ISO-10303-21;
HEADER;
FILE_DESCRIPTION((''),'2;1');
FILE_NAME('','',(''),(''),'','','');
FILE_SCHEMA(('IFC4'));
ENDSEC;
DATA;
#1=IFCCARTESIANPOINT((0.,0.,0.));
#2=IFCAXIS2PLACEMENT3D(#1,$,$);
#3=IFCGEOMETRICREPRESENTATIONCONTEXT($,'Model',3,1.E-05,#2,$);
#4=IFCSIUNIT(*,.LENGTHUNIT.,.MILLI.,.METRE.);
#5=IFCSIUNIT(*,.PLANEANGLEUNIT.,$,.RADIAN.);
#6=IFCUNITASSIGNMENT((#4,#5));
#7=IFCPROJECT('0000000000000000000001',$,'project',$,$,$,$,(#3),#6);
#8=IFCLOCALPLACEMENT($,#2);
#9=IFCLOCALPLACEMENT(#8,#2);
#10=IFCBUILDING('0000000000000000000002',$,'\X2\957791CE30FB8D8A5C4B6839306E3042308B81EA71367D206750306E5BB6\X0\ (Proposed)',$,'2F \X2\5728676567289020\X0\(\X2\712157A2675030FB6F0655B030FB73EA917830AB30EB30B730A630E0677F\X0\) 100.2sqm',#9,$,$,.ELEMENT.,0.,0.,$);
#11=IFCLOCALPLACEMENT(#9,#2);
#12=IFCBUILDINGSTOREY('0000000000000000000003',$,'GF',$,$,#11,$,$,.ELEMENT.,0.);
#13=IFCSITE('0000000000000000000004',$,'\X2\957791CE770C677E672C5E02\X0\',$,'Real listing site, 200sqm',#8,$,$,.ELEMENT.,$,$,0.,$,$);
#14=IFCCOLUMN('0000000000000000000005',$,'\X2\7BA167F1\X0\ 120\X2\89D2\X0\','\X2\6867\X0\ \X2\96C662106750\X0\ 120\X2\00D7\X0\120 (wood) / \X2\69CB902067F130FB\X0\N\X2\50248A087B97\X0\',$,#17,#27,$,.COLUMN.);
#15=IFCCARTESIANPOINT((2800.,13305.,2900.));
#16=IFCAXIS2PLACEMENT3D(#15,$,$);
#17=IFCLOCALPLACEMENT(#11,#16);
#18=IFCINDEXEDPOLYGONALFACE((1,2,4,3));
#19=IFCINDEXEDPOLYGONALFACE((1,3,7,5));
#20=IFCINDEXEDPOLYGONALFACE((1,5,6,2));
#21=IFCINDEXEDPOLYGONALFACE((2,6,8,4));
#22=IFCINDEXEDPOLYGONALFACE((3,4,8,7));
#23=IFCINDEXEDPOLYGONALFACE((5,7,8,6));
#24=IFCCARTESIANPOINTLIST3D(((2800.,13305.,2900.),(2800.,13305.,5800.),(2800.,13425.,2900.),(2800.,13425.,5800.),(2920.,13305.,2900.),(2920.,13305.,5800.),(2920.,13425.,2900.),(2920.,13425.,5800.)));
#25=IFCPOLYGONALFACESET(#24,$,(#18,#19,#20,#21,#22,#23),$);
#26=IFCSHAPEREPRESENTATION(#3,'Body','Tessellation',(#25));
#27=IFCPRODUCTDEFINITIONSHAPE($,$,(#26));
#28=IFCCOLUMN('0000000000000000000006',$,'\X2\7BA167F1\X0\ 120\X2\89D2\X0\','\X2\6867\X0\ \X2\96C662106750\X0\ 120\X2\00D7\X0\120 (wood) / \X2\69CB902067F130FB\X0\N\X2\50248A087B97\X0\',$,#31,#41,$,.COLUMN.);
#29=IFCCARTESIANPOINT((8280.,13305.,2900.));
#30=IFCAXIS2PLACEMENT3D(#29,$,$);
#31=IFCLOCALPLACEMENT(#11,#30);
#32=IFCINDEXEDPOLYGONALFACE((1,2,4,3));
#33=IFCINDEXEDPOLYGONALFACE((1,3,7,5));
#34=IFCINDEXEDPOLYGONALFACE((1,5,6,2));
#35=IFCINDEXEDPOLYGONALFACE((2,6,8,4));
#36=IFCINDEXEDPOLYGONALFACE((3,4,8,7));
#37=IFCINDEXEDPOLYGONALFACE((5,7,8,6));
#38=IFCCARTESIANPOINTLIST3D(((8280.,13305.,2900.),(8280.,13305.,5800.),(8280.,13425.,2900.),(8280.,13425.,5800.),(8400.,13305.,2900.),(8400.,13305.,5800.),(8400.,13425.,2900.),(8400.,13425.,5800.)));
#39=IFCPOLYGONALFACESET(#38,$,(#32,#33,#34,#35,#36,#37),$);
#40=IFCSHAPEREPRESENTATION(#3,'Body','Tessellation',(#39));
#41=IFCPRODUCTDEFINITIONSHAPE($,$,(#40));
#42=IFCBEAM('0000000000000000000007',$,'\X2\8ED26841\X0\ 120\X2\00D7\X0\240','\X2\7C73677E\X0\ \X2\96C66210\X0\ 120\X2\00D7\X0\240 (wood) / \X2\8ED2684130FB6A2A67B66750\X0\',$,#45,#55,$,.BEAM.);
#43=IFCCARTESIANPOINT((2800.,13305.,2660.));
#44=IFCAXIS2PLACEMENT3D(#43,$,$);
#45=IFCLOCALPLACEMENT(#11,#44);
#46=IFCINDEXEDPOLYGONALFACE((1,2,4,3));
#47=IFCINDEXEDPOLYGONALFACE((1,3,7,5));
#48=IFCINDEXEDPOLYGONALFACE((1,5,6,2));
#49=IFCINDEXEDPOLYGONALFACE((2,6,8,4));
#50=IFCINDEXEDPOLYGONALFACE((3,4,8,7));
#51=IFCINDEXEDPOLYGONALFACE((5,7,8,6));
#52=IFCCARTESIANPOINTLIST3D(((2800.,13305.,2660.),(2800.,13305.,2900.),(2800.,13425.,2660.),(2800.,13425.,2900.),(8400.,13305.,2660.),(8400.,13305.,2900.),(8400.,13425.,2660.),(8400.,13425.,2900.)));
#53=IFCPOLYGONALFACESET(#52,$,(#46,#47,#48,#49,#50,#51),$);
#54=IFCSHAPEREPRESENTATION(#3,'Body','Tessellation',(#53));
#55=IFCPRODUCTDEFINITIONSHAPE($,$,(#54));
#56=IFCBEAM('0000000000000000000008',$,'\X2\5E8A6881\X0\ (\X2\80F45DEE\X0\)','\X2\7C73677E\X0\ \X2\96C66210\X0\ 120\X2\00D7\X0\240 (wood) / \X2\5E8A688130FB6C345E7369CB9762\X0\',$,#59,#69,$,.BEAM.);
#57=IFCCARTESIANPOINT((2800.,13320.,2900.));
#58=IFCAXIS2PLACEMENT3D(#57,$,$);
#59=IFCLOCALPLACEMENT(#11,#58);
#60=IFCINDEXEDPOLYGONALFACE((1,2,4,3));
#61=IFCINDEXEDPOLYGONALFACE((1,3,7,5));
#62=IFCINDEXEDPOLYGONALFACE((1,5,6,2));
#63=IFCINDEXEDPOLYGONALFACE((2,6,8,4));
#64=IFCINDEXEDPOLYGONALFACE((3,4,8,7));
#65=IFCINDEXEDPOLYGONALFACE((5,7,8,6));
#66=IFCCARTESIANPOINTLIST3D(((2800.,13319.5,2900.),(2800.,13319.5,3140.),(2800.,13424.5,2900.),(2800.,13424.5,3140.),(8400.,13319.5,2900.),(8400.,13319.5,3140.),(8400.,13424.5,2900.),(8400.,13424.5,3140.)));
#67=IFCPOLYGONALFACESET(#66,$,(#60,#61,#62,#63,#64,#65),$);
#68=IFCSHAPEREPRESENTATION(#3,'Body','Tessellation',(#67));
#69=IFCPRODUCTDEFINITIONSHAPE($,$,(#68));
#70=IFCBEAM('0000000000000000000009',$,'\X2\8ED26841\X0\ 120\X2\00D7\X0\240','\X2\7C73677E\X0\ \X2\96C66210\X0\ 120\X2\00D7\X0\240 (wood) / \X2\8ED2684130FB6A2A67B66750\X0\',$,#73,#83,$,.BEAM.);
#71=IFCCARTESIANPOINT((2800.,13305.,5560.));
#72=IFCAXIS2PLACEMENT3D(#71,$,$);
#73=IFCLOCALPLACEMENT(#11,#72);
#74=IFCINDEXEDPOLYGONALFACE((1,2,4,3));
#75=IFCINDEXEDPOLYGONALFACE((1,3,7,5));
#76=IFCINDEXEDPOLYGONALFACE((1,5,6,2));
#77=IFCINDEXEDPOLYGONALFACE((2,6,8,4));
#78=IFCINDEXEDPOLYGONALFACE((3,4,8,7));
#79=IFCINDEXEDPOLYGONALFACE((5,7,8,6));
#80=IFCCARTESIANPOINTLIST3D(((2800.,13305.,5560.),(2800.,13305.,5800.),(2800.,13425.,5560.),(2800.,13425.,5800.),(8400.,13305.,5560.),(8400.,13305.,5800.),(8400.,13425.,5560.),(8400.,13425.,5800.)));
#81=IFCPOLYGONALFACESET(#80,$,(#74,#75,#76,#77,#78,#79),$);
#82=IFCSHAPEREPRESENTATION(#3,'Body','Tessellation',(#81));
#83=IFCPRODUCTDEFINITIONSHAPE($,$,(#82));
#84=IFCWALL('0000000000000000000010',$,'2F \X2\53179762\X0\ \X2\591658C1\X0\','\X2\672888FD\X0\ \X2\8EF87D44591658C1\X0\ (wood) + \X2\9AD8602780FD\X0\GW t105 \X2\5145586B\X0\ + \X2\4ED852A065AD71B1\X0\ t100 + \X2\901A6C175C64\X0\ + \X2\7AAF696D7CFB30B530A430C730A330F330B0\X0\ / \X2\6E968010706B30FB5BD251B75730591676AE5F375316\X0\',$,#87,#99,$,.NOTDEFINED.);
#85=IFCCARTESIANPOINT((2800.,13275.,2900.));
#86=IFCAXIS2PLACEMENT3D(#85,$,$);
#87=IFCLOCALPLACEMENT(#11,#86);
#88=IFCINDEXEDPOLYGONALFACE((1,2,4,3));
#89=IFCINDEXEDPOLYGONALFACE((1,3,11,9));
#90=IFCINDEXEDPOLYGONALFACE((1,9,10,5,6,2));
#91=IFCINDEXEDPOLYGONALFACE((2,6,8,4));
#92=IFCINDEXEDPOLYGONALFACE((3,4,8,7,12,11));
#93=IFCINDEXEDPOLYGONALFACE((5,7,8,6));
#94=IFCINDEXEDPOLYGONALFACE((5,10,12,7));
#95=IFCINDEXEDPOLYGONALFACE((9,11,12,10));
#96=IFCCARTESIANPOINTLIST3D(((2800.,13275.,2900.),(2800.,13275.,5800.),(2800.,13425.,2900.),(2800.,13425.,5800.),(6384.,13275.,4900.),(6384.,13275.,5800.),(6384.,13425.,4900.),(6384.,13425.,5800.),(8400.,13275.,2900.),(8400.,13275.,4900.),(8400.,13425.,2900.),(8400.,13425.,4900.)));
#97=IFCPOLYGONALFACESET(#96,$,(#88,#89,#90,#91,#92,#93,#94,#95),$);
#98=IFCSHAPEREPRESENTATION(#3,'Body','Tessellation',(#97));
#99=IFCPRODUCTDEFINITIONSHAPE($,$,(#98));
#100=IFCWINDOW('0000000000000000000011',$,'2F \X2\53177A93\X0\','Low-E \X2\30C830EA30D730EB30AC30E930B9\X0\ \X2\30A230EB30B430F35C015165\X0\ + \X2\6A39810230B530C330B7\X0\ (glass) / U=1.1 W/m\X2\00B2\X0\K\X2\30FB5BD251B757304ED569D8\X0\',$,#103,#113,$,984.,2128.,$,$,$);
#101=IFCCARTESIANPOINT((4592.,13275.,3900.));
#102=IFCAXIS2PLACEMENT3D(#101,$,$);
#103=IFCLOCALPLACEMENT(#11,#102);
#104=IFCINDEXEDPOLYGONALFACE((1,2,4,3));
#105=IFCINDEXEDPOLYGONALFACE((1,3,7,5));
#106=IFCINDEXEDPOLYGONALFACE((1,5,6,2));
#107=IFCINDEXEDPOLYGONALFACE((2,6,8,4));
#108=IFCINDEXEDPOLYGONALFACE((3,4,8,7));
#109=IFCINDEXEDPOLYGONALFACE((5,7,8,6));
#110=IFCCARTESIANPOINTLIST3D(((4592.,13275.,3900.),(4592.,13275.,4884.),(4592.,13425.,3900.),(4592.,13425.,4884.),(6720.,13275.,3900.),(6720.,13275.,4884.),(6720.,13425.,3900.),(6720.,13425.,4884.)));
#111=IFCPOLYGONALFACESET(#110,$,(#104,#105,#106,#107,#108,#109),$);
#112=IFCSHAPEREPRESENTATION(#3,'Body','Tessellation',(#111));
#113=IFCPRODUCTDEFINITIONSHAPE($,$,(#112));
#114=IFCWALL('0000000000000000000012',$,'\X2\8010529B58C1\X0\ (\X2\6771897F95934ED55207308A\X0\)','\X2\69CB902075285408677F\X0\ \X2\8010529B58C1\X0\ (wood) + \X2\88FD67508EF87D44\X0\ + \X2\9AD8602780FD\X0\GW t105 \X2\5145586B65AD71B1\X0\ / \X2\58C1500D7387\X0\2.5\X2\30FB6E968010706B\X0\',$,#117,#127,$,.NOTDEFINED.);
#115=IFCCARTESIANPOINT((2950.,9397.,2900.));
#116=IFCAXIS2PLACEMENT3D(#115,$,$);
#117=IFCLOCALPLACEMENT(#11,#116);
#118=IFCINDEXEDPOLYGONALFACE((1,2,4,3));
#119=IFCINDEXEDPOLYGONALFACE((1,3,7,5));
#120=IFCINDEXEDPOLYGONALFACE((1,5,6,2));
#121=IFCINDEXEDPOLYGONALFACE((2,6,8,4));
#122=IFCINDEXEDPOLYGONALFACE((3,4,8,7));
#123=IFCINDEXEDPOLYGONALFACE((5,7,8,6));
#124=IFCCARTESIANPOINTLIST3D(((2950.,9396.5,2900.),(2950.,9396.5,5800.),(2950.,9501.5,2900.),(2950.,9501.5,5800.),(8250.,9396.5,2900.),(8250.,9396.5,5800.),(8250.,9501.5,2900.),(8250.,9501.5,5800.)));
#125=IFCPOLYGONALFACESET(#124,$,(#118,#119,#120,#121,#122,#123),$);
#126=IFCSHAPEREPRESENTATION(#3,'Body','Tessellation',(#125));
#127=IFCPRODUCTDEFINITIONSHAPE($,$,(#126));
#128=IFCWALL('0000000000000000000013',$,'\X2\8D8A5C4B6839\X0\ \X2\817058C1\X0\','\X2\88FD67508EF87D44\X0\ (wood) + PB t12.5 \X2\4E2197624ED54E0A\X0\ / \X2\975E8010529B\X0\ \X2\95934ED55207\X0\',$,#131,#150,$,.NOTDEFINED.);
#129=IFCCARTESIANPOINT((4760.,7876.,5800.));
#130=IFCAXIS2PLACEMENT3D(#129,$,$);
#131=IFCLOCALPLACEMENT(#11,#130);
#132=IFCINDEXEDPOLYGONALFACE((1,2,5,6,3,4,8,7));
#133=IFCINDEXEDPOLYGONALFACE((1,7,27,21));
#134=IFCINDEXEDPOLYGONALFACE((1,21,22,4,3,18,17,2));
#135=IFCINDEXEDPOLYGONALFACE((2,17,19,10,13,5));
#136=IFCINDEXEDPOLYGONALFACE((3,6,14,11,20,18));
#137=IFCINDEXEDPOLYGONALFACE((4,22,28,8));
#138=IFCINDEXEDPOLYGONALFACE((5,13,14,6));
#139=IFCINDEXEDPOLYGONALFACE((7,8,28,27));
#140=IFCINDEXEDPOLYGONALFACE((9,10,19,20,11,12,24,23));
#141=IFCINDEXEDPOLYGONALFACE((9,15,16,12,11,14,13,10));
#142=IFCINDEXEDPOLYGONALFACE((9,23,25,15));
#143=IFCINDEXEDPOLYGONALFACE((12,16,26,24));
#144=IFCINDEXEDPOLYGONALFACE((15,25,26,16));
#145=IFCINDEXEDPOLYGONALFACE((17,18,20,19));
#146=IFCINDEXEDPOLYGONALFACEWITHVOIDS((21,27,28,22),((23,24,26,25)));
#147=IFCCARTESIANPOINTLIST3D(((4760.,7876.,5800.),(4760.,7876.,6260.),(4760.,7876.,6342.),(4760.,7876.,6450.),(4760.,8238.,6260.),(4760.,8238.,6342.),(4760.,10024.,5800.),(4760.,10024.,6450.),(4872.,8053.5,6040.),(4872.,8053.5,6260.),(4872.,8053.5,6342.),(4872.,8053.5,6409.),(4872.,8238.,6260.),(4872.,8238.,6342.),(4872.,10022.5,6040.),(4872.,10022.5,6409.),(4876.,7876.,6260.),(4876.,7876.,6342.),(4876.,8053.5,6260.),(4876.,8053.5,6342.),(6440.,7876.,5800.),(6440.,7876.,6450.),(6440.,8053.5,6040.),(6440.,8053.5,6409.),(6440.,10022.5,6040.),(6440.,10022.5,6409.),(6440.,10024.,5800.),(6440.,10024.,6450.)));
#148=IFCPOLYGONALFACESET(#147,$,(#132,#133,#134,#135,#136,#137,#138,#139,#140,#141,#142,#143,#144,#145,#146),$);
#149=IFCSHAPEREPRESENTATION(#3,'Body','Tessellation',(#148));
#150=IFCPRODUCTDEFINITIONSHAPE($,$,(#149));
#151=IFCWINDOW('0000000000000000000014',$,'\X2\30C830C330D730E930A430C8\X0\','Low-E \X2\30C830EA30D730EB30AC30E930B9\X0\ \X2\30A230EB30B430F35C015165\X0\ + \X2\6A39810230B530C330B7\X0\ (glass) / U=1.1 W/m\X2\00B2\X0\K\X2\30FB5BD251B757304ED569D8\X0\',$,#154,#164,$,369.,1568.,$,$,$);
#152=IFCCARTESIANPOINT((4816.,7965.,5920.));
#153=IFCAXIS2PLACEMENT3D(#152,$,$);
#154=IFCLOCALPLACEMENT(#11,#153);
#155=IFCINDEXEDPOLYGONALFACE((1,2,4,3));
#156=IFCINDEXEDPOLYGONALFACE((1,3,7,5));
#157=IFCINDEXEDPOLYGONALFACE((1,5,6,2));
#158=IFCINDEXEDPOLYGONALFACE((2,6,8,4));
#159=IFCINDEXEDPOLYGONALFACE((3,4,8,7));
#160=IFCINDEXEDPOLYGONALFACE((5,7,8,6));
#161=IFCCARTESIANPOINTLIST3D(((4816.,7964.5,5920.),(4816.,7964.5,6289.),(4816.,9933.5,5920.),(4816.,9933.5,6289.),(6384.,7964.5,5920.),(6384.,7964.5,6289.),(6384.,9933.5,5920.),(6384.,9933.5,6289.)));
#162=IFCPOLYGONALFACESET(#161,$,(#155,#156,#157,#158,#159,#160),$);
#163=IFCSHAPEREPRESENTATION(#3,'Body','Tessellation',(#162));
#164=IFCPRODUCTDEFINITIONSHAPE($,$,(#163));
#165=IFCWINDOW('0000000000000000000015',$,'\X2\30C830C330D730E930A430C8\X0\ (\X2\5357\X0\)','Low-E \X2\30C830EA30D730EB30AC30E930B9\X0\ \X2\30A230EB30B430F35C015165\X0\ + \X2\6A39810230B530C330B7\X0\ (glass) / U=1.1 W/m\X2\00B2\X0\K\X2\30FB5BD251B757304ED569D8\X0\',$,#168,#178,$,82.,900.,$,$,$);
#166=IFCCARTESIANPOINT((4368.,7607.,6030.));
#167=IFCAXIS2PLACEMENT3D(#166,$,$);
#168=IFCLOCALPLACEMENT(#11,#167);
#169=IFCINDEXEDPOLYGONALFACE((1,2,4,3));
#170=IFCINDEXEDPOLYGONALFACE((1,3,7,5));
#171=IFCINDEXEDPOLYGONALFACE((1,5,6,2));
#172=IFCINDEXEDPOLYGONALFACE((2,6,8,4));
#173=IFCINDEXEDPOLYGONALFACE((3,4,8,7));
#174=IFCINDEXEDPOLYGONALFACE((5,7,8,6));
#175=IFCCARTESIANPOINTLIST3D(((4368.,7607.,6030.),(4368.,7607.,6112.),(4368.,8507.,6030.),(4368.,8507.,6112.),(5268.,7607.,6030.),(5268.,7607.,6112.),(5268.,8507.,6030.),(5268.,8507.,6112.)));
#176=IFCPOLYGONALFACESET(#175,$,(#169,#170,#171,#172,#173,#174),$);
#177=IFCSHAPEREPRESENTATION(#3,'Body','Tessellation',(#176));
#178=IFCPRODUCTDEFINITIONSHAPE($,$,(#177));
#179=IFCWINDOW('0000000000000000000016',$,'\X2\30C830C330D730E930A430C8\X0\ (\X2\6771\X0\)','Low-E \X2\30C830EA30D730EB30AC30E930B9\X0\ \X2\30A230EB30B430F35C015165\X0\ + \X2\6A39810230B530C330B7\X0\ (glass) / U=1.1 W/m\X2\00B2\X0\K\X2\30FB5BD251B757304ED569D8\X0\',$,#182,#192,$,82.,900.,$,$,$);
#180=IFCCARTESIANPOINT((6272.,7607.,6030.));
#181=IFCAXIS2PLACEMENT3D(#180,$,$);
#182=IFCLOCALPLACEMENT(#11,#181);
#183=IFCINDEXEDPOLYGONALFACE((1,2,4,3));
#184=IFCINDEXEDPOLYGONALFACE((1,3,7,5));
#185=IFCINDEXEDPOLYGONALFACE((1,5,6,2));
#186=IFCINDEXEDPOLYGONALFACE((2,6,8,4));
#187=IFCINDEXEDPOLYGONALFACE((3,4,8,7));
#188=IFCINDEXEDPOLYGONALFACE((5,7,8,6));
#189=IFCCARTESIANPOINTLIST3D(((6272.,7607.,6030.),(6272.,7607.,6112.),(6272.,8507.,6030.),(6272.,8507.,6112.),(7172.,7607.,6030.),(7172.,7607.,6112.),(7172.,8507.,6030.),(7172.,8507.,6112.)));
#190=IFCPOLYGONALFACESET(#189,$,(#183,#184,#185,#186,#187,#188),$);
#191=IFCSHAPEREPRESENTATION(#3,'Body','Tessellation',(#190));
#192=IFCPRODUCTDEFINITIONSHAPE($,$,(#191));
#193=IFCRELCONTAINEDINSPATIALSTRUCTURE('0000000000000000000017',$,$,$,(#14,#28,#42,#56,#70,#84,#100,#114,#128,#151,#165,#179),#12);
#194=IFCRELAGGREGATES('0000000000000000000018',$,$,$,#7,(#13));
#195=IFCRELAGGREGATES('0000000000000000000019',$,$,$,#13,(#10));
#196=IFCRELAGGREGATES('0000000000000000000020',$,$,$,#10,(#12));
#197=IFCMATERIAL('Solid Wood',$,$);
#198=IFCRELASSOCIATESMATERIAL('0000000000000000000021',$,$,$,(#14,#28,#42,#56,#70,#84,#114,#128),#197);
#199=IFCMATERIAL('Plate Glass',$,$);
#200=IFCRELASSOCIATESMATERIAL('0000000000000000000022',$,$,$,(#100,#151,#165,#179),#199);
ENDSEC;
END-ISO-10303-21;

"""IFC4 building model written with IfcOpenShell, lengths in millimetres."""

from ifc_helpers import new_model, si_unit, frame, frame_2d, origin, place, context, project, spatial, rectangle, extrude, material, element, fill, save


model = new_model("IFC4")

# Units and contexts
model_context = context("Model", 3, precision=1e-05, world=origin())
ifc_project = project(units=[si_unit("LENGTHUNIT", "METRE", prefix="MILLI"), si_unit("PLANEANGLEUNIT", "RADIAN")], contexts=[model_context])

# Site, building, storey
site_placement = place(None, origin())
site = spatial("IfcSite", under=ifc_project, at=site_placement, Name="長野県松本市", ObjectType="Real listing site, 200sqm", CompositionType="ELEMENT", RefElevation=0.0)
building_placement = place(site_placement, origin())
building = spatial("IfcBuilding", under=site, at=building_placement, Name="長野・越屋根のある自然素材の家 (Proposed)", ObjectType="2F 在来木造(無垢材・漆喰・珪酸カルシウム板) 100.2sqm", CompositionType="ELEMENT", ElevationOfRefHeight=0.0, ElevationOfTerrain=0.0)
storey_placement = place(building_placement, origin())
storey = spatial("IfcBuildingStorey", under=building, at=storey_placement, Name="GF", CompositionType="ELEMENT", Elevation=0.0)

# Columns
ifc_material_1 = material(Name="Solid Wood")
column_1_placement = place(storey_placement, frame((2800.0, 13305.0, 2900.0)))
element("IfcColumn", 1, at=column_1_placement, inside=storey, material=ifc_material_1, Name="管柱 120角", Description="桧 集成材 120×120 (wood) / 構造柱・N値計算", PredefinedType="COLUMN", context=model_context, shape_type="SweptSolid", body=[
    extrude(rectangle(XDim=120.0, YDim=120.0, at=frame_2d((60.0, 60.0))), frame((2800.0, 13305.0, 2900.0)), (0.0, 0.0, 1.0), 2900.0),
])
column_2_placement = place(storey_placement, frame((8280.0, 13305.0, 2900.0)))
element("IfcColumn", 2, at=column_2_placement, inside=storey, material=ifc_material_1, Name="管柱 120角", Description="桧 集成材 120×120 (wood) / 構造柱・N値計算", PredefinedType="COLUMN", context=model_context, shape_type="SweptSolid", body=[
    extrude(rectangle(XDim=120.0, YDim=120.0, at=frame_2d((60.0, 60.0))), frame((8280.0, 13305.0, 2900.0)), (0.0, 0.0, 1.0), 2900.0),
])

# Beams
beam_1_placement = place(storey_placement, frame((2800.0, 13305.0, 2660.0)))
element("IfcBeam", 3, at=beam_1_placement, inside=storey, material=ifc_material_1, Name="軒桁 120×240", Description="米松 集成 120×240 (wood) / 軒桁・横架材", PredefinedType="BEAM", context=model_context, shape_type="SweptSolid", body=[
    extrude(rectangle(XDim=5600.0, YDim=120.0, at=frame_2d((2800.0, 60.0))), frame((2800.0, 13305.0, 2660.0)), (0.0, 0.0, 1.0), 240.0),
])
beam_2_placement = place(storey_placement, frame((2800.0, 13320.0, 2900.0)))
element("IfcBeam", 4, at=beam_2_placement, inside=storey, material=ifc_material_1, Name="床梁 (胴差)", Description="米松 集成 120×240 (wood) / 床梁・水平構面", PredefinedType="BEAM", context=model_context, shape_type="SweptSolid", body=[
    extrude(rectangle(XDim=5600.0, YDim=105.0, at=frame_2d((2800.0, 52.0))), frame((2800.0, 13320.0, 2900.0)), (0.0, 0.0, 1.0), 240.0),
])
beam_3_placement = place(storey_placement, frame((2800.0, 13305.0, 5560.0)))
element("IfcBeam", 5, at=beam_3_placement, inside=storey, material=ifc_material_1, Name="軒桁 120×240", Description="米松 集成 120×240 (wood) / 軒桁・横架材", PredefinedType="BEAM", context=model_context, shape_type="SweptSolid", body=[
    extrude(rectangle(XDim=5600.0, YDim=120.0, at=frame_2d((2800.0, 60.0))), frame((2800.0, 13305.0, 5560.0)), (0.0, 0.0, 1.0), 240.0),
])

# Wall, opening, window
wall_1_placement = place(storey_placement, frame((2800.0, 13275.0, 2900.0)))
wall_1 = element("IfcWall", 6, at=wall_1_placement, inside=storey, material=ifc_material_1, Name="2F 北面 外壁", Description="木製 軸組外壁 (wood) + 高性能GW t105 充填 + 付加断熱 t100 + 通気層 + 窯業系サイディング / 準耐火・寒冷地外皮強化", PredefinedType="NOTDEFINED", context=model_context, shape_type="SweptSolid", body=[
    extrude(rectangle(XDim=5600.0, YDim=150.0, at=frame_2d((2800.0, 75.0))), frame((2800.0, 13275.0, 2900.0)), (0.0, 0.0, 1.0), 2900.0),
])
opening_1_placement = place(storey_placement, frame((4592.0, 13275.0, 3900.0)))
opening_1 = element("IfcOpeningElement", 7, at=opening_1_placement, cuts=wall_1, PredefinedType="NOTDEFINED", context=model_context, shape_type="SweptSolid", body=[
    extrude(rectangle(XDim=2128.0, YDim=150.0, at=frame_2d((1064.0, 75.0))), frame((4592.0, 13275.0, 3900.0)), (0.0, 0.0, 1.0), 984.0),
])
ifc_material_2 = material(Name="Plate Glass")
window_1_placement = place(storey_placement, frame((4592.0, 13275.0, 3900.0)))
window_1 = element("IfcWindow", 8, at=window_1_placement, inside=storey, material=ifc_material_2, Name="2F 北窓", Description="Low-E トリプルガラス アルゴン封入 + 樹脂サッシ (glass) / U=1.1 W/m²K・寒冷地仕様", OverallHeight=984.0, OverallWidth=2128.0, context=model_context, shape_type="SweptSolid", body=[
    extrude(rectangle(XDim=2128.0, YDim=150.0, at=frame_2d((1064.0, 75.0))), frame((4592.0, 13275.0, 3900.0)), (0.0, 0.0, 1.0), 984.0),
])
fill(opening_1, window_1)

# Wall
wall_2_placement = place(storey_placement, frame((2950.0, 9397.0, 2900.0)))
element("IfcWall", 9, at=wall_2_placement, inside=storey, material=ifc_material_1, Name="耐力壁 (東西間仕切り)", Description="構造用合板 耐力壁 (wood) + 製材軸組 + 高性能GW t105 充填断熱 / 壁倍率2.5・準耐火", PredefinedType="NOTDEFINED", context=model_context, shape_type="SweptSolid", body=[
    extrude(rectangle(XDim=5300.0, YDim=105.0, at=frame_2d((2650.0, 52.0))), frame((2950.0, 9397.0, 2900.0)), (0.0, 0.0, 1.0), 2900.0),
])

# Wall, openings, windows
wall_3_placement = place(storey_placement, frame((4760.0, 7876.0, 5800.0)))
wall_3 = element("IfcWall", 10, at=wall_3_placement, inside=storey, material=ifc_material_1, Name="越屋根 腰壁", Description="製材軸組 (wood) + PB t12.5 両面仕上 / 非耐力 間仕切", PredefinedType="NOTDEFINED", context=model_context, shape_type="SweptSolid", body=[
    extrude(rectangle(XDim=1680.0, YDim=2148.0, at=frame_2d((840.0, 1074.0))), frame((4760.0, 7876.0, 5800.0)), (0.0, 0.0, 1.0), 650.0),
])
opening_2_placement = place(storey_placement, frame((4816.0, 7965.0, 5920.0)))
opening_2 = element("IfcOpeningElement", 11, at=opening_2_placement, cuts=wall_3, PredefinedType="NOTDEFINED", context=model_context, shape_type="SweptSolid", body=[
    extrude(rectangle(XDim=1568.0, YDim=1969.0, at=frame_2d((784.0, 984.0))), frame((4816.0, 7965.0, 5920.0)), (0.0, 0.0, 1.0), 369.0),
])
opening_3_placement = place(storey_placement, frame((4368.0, 7607.0, 6030.0)))
opening_3 = element("IfcOpeningElement", 12, at=opening_3_placement, cuts=wall_3, PredefinedType="NOTDEFINED", context=model_context, shape_type="SweptSolid", body=[
    extrude(rectangle(XDim=900.0, YDim=900.0, at=frame_2d((450.0, 450.0))), frame((4368.0, 7607.0, 6030.0)), (0.0, 0.0, 1.0), 82.0),
])
opening_4_placement = place(storey_placement, frame((6272.0, 7607.0, 6030.0)))
opening_4 = element("IfcOpeningElement", 13, at=opening_4_placement, cuts=wall_3, PredefinedType="NOTDEFINED", context=model_context, shape_type="SweptSolid", body=[
    extrude(rectangle(XDim=900.0, YDim=900.0, at=frame_2d((450.0, 450.0))), frame((6272.0, 7607.0, 6030.0)), (0.0, 0.0, 1.0), 82.0),
])
window_2_placement = place(storey_placement, frame((4816.0, 7965.0, 5920.0)))
window_2 = element("IfcWindow", 14, at=window_2_placement, inside=storey, material=ifc_material_2, Name="トップライト", Description="Low-E トリプルガラス アルゴン封入 + 樹脂サッシ (glass) / U=1.1 W/m²K・寒冷地仕様", OverallHeight=369.0, OverallWidth=1568.0, context=model_context, shape_type="SweptSolid", body=[
    extrude(rectangle(XDim=1568.0, YDim=1969.0, at=frame_2d((784.0, 984.0))), frame((4816.0, 7965.0, 5920.0)), (0.0, 0.0, 1.0), 369.0),
])
fill(opening_2, window_2)
window_3_placement = place(storey_placement, frame((4368.0, 7607.0, 6030.0)))
window_3 = element("IfcWindow", 15, at=window_3_placement, inside=storey, material=ifc_material_2, Name="トップライト (南)", Description="Low-E トリプルガラス アルゴン封入 + 樹脂サッシ (glass) / U=1.1 W/m²K・寒冷地仕様", OverallHeight=82.0, OverallWidth=900.0, context=model_context, shape_type="SweptSolid", body=[
    extrude(rectangle(XDim=900.0, YDim=900.0, at=frame_2d((450.0, 450.0))), frame((4368.0, 7607.0, 6030.0)), (0.0, 0.0, 1.0), 82.0),
])
fill(opening_3, window_3)
window_4_placement = place(storey_placement, frame((6272.0, 7607.0, 6030.0)))
window_4 = element("IfcWindow", 16, at=window_4_placement, inside=storey, material=ifc_material_2, Name="トップライト (東)", Description="Low-E トリプルガラス アルゴン封入 + 樹脂サッシ (glass) / U=1.1 W/m²K・寒冷地仕様", OverallHeight=82.0, OverallWidth=900.0, context=model_context, shape_type="SweptSolid", body=[
    extrude(rectangle(XDim=900.0, YDim=900.0, at=frame_2d((450.0, 450.0))), frame((6272.0, 7607.0, 6030.0)), (0.0, 0.0, 1.0), 82.0),
])
fill(opening_4, window_4)

save(model, "model.ifc")
